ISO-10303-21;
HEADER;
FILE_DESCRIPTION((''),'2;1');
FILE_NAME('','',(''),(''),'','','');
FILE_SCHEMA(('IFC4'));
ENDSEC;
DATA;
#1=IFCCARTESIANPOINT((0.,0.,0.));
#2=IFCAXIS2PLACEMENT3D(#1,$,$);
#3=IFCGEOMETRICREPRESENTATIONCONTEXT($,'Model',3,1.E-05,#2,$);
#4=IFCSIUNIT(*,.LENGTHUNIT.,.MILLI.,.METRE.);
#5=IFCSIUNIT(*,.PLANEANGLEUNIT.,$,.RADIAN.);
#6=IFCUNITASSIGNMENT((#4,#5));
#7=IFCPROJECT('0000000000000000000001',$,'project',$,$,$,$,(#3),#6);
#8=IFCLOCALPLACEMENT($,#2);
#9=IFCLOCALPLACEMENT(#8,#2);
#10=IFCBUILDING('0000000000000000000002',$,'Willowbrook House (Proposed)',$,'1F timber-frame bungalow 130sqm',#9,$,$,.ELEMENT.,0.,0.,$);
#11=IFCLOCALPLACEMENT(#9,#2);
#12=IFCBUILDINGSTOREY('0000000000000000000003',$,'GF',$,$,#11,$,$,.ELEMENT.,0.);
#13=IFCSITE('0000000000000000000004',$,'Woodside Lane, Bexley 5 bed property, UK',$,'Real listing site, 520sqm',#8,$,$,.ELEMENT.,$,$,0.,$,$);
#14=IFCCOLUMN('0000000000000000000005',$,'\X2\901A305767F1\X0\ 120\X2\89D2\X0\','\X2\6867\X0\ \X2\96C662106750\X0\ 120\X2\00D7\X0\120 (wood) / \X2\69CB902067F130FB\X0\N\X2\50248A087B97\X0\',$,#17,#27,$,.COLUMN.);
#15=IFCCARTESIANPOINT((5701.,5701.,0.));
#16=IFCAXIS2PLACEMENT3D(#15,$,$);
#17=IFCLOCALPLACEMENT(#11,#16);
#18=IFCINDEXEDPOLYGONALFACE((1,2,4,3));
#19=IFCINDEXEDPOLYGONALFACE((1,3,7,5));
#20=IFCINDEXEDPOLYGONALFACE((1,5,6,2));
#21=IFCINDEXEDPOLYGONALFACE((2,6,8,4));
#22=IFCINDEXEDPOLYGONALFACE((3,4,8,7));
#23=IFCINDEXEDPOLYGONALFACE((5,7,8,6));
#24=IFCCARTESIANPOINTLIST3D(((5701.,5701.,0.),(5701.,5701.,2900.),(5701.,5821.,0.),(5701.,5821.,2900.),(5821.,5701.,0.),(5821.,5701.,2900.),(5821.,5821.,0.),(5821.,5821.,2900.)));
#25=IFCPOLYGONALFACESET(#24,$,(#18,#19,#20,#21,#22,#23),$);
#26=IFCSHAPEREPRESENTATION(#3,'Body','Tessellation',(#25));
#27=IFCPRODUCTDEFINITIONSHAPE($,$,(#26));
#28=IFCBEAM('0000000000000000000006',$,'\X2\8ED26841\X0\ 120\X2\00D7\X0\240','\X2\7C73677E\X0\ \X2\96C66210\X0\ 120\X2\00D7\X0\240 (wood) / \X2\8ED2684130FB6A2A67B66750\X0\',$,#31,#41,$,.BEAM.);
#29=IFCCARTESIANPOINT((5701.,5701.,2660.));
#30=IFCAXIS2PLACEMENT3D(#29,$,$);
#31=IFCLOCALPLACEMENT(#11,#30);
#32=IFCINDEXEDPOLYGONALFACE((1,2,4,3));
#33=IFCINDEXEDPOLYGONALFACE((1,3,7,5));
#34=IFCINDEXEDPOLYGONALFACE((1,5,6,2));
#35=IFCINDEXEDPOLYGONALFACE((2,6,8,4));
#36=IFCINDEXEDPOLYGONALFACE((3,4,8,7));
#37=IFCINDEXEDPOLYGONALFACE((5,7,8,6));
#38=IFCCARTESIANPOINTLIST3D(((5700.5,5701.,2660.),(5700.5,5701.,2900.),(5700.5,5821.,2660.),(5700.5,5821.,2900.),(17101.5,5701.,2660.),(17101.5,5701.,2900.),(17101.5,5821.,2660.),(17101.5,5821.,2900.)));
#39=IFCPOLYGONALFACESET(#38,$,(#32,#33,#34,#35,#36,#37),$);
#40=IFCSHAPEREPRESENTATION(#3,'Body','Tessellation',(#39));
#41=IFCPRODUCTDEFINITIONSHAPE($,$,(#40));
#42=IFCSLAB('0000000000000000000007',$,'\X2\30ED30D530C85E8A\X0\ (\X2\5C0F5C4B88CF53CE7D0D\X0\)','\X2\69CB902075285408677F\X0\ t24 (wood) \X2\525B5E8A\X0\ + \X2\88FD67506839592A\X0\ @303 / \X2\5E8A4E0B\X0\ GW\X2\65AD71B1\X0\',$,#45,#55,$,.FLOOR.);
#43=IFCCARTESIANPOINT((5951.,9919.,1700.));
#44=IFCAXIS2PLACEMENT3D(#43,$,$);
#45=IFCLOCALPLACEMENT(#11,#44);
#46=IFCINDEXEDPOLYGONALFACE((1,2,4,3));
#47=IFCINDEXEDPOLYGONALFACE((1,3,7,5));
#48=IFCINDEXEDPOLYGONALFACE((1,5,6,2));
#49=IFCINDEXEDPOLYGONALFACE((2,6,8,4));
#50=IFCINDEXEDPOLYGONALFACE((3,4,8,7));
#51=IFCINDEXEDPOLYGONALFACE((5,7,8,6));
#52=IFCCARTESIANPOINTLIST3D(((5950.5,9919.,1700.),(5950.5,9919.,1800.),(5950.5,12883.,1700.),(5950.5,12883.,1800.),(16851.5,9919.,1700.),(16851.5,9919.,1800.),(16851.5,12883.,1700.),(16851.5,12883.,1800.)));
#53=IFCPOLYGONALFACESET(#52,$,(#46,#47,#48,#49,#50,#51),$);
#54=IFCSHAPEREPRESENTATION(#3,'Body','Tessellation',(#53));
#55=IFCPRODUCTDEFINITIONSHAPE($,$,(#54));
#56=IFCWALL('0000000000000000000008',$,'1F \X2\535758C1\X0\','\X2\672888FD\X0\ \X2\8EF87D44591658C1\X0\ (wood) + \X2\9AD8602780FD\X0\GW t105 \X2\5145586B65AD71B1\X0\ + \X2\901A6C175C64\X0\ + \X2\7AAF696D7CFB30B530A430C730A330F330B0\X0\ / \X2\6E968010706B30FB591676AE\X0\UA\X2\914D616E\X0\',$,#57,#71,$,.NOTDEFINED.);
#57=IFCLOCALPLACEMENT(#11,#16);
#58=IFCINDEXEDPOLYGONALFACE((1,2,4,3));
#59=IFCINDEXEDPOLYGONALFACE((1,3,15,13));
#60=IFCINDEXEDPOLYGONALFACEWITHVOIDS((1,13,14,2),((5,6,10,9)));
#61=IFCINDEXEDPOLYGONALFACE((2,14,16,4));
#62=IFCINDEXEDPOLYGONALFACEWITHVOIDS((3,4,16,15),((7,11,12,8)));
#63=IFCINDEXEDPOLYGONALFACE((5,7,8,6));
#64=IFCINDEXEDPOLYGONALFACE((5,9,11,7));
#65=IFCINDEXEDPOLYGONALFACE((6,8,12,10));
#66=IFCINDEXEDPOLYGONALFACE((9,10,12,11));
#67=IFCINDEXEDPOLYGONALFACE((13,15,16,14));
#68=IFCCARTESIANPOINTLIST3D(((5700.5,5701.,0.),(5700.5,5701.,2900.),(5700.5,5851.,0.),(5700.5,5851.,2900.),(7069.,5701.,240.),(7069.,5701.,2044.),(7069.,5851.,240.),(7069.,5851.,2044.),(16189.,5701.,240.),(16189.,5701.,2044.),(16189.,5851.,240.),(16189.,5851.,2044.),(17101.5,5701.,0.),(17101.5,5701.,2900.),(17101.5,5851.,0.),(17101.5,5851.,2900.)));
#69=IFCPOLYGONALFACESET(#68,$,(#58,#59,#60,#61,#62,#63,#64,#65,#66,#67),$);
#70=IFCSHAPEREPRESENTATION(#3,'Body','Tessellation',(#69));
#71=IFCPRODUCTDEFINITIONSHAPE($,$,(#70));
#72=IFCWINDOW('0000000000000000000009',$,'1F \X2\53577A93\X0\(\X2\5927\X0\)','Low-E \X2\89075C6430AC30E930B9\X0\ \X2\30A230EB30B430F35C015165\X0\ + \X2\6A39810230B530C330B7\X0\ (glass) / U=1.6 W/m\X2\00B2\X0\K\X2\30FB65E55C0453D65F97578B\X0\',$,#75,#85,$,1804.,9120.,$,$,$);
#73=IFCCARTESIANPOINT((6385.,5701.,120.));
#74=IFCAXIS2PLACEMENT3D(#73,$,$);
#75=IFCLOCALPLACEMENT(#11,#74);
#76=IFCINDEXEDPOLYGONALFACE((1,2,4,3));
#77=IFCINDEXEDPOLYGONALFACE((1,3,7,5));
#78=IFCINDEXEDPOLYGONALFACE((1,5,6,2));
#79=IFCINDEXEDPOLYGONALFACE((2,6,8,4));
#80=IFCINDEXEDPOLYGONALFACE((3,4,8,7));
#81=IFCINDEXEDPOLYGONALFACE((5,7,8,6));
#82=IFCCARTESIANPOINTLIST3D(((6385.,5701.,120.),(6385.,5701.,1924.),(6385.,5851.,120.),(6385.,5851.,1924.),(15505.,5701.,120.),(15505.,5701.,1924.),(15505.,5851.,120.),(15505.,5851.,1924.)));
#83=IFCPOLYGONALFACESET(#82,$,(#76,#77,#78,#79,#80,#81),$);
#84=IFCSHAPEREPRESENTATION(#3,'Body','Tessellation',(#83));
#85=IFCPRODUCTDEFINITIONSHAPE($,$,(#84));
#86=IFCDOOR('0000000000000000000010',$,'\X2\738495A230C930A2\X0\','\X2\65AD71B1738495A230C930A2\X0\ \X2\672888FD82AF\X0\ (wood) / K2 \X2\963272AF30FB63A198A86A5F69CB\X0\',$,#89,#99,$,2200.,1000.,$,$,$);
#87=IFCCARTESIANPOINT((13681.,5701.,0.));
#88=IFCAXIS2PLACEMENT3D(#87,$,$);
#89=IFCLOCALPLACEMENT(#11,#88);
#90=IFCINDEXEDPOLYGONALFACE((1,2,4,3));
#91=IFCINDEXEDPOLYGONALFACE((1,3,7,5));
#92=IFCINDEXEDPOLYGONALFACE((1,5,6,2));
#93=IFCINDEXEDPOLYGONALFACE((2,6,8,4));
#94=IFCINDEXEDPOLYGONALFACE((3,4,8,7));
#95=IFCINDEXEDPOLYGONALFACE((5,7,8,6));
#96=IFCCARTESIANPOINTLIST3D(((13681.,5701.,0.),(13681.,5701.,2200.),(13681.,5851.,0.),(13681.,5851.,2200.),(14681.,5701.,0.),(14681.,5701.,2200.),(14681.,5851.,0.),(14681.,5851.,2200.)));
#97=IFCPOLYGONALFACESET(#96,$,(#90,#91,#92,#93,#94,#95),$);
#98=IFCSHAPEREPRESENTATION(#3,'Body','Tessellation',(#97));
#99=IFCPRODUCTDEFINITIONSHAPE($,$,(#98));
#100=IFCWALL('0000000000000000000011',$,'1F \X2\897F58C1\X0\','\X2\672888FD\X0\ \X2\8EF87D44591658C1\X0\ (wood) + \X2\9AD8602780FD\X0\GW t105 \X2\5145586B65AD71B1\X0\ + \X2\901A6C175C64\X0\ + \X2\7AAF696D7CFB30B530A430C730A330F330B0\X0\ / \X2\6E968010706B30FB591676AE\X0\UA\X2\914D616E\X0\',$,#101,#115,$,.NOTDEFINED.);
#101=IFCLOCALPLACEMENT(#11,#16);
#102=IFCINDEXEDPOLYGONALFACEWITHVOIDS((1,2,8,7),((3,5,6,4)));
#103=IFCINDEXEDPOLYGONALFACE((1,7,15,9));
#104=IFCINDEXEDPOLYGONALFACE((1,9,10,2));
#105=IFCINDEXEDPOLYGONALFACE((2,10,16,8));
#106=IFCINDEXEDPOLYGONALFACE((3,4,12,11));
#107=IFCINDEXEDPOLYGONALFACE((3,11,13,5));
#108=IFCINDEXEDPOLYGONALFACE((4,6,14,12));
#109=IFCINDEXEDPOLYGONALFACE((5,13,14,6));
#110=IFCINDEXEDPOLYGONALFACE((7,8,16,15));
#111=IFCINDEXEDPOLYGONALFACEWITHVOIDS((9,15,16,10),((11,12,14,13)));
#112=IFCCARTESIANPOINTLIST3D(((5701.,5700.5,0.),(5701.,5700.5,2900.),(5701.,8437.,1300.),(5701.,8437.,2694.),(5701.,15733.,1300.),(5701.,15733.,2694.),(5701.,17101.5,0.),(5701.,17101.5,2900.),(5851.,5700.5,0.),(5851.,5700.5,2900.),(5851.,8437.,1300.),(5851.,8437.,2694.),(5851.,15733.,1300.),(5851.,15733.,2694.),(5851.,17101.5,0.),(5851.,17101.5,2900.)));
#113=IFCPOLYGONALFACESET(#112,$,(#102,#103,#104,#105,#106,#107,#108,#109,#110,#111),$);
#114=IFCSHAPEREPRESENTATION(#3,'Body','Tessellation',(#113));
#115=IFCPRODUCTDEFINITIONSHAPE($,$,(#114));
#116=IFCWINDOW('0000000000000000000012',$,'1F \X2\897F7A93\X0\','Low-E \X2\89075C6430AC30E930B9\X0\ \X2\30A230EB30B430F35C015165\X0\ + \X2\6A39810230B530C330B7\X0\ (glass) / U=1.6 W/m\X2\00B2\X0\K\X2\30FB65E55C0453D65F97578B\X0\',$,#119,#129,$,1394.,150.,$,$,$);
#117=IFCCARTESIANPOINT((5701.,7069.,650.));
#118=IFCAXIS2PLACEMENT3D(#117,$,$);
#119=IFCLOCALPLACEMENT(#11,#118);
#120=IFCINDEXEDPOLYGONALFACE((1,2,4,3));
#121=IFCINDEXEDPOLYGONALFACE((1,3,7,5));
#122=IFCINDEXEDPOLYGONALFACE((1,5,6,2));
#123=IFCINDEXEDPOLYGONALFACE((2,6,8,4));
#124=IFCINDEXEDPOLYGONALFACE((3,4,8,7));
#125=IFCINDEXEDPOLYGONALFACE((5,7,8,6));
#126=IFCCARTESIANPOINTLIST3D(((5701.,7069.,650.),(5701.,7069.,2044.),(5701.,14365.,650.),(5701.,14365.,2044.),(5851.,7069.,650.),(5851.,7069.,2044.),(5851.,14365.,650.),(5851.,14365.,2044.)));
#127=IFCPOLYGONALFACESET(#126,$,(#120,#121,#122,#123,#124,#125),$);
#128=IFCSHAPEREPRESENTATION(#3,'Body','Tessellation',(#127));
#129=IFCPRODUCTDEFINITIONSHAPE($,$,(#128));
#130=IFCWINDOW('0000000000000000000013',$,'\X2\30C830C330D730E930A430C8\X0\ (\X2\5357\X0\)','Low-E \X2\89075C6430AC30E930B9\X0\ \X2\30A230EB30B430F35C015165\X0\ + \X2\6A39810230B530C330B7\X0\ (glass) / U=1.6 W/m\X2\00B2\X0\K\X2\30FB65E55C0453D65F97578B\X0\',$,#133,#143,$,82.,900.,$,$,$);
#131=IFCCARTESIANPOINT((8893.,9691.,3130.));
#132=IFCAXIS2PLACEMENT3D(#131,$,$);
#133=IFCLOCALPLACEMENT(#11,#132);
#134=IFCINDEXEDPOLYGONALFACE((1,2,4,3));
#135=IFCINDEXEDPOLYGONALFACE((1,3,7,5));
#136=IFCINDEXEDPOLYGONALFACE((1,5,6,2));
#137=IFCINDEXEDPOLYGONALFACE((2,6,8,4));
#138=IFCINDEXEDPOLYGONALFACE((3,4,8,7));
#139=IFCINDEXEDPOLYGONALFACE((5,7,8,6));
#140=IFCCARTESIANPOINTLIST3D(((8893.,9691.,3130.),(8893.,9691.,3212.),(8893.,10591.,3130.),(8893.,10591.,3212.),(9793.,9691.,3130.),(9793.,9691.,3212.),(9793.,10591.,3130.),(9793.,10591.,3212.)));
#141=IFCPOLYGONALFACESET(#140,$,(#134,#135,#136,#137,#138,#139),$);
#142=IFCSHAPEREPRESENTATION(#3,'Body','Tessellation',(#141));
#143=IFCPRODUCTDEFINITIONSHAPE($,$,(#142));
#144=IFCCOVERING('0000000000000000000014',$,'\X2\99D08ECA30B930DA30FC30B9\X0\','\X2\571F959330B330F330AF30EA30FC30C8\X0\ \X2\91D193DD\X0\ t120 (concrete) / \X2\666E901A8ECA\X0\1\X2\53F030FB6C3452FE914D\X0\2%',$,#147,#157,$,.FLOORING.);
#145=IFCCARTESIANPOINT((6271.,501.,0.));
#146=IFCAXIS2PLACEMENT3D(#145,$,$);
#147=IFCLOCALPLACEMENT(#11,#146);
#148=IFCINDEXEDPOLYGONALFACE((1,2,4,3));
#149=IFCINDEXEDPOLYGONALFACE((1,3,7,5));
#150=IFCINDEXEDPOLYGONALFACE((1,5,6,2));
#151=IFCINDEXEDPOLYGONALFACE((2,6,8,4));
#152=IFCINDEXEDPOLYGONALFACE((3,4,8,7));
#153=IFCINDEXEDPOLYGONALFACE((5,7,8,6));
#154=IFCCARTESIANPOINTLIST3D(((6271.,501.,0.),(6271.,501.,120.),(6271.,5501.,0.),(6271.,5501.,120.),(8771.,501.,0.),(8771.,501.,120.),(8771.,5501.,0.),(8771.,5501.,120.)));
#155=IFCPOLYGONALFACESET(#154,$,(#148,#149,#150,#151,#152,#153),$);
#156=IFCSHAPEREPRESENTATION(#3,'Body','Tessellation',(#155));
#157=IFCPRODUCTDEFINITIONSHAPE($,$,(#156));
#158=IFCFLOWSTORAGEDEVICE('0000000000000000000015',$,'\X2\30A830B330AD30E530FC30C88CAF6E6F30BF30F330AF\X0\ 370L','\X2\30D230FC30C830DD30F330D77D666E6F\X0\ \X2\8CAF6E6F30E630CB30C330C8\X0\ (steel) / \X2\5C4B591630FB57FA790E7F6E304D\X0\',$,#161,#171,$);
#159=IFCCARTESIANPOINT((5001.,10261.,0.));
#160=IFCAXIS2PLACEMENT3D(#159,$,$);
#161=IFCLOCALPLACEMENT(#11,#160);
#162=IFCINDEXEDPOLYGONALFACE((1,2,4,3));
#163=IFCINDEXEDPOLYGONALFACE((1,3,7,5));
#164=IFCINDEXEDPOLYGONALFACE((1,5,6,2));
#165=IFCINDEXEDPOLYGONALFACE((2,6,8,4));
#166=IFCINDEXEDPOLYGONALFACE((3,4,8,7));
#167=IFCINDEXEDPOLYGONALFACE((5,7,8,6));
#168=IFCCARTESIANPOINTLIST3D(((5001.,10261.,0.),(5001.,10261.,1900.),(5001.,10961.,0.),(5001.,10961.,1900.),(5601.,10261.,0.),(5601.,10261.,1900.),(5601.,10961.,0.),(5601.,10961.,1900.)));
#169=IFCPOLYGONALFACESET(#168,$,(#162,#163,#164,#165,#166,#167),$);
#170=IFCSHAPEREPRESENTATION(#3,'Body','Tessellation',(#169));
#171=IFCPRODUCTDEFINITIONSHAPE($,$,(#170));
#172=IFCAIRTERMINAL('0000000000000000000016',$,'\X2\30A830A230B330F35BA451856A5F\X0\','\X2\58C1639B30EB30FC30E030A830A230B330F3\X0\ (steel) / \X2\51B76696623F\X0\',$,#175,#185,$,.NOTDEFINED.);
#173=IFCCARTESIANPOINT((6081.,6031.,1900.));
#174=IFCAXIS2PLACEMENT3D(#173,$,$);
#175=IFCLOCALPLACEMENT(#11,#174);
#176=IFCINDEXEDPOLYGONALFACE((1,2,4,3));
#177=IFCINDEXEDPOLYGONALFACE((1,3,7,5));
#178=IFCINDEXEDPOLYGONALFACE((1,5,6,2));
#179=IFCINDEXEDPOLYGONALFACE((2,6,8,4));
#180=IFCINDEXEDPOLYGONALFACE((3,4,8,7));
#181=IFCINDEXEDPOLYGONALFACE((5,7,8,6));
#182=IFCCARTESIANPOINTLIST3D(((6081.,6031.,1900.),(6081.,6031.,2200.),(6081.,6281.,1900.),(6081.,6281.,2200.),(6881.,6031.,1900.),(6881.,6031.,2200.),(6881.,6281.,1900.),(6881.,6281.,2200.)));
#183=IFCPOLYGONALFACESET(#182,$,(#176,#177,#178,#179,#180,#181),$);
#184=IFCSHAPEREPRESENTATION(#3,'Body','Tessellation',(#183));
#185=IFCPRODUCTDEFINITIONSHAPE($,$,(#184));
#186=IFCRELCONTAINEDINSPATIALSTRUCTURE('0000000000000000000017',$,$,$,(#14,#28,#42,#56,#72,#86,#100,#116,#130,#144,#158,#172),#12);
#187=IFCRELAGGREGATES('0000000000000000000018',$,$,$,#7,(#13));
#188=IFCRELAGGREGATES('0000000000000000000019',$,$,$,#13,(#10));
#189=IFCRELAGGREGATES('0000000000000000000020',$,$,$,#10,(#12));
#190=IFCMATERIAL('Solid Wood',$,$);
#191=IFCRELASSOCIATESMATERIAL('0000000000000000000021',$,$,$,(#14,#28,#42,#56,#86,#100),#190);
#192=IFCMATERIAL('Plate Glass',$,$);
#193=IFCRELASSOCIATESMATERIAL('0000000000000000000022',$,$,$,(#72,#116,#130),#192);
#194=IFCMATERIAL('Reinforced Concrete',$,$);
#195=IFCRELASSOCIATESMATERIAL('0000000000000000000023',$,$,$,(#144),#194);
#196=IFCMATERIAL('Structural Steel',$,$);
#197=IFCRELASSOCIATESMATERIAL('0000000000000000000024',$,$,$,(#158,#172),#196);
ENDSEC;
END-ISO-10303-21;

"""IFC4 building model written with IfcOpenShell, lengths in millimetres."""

from ifc_helpers import new_model, si_unit, frame, frame_2d, origin, place, context, project, spatial, rectangle, extrude, material, element, fill, save


model = new_model("IFC4")

# Units and contexts
model_context = context("Model", 3, precision=1e-05, world=origin())
ifc_project = project(units=[si_unit("LENGTHUNIT", "METRE", prefix="MILLI"), si_unit("PLANEANGLEUNIT", "RADIAN")], contexts=[model_context])

# Site, building, storey
site_placement = place(None, origin())
site = spatial("IfcSite", under=ifc_project, at=site_placement, Name="Woodside Lane, Bexley 5 bed property, UK", ObjectType="Real listing site, 520sqm", CompositionType="ELEMENT", RefElevation=0.0)
building_placement = place(site_placement, origin())
building = spatial("IfcBuilding", under=site, at=building_placement, Name="Willowbrook House (Proposed)", ObjectType="1F timber-frame bungalow 130sqm", CompositionType="ELEMENT", ElevationOfRefHeight=0.0, ElevationOfTerrain=0.0)
storey_placement = place(building_placement, origin())
storey = spatial("IfcBuildingStorey", under=building, at=storey_placement, Name="GF", CompositionType="ELEMENT", Elevation=0.0)

# Column
ifc_material_1 = material(Name="Solid Wood")
column_1_placement = place(storey_placement, frame((5701.0, 5701.0, 0.0)))
element("IfcColumn", 1, at=column_1_placement, inside=storey, material=ifc_material_1, Name="通し柱 120角", Description="桧 集成材 120×120 (wood) / 構造柱・N値計算", PredefinedType="COLUMN", context=model_context, shape_type="SweptSolid", body=[
    extrude(rectangle(XDim=120.0, YDim=120.0, at=frame_2d((60.0, 60.0))), frame((5701.0, 5701.0, 0.0)), (0.0, 0.0, 1.0), 2900.0),
])

# Beam
beam_1_placement = place(storey_placement, frame((5701.0, 5701.0, 2660.0)))
element("IfcBeam", 2, at=beam_1_placement, inside=storey, material=ifc_material_1, Name="軒桁 120×240", Description="米松 集成 120×240 (wood) / 軒桁・横架材", PredefinedType="BEAM", context=model_context, shape_type="SweptSolid", body=[
    extrude(rectangle(XDim=11401.0, YDim=120.0, at=frame_2d((5700.0, 60.0))), frame((5701.0, 5701.0, 2660.0)), (0.0, 0.0, 1.0), 240.0),
])

# Slab
ifc_material_2 = material(Name="Reinforced Concrete")
slab_1_placement = place(storey_placement, frame((5951.0, 9919.0, 1700.0)))
element("IfcSlab", 3, at=slab_1_placement, inside=storey, material=ifc_material_1, Name="ロフト床 (小屋裏収納)", Description="構造用合板 t24 (wood) 剛床 + 製材根太 @303 / 床下 GW断熱", PredefinedType="FLOOR", context=model_context, shape_type="SweptSolid", body=[
    extrude(rectangle(XDim=10901.0, YDim=2964.0, at=frame_2d((5450.0, 1482.0))), frame((5951.0, 9919.0, 1700.0)), (0.0, 0.0, 1.0), 100.0),
])

# Wall, openings, window, door
wall_1_placement = place(storey_placement, frame((5701.0, 5701.0, 0.0)))
wall_1 = element("IfcWall", 4, at=wall_1_placement, inside=storey, material=ifc_material_1, Name="1F 南壁", Description="木製 軸組外壁 (wood) + 高性能GW t105 充填断熱 + 通気層 + 窯業系サイディング / 準耐火・外皮UA配慮", PredefinedType="NOTDEFINED", context=model_context, shape_type="SweptSolid", body=[
    extrude(rectangle(XDim=11401.0, YDim=150.0, at=frame_2d((5700.0, 75.0))), frame((5701.0, 5701.0, 0.0)), (0.0, 0.0, 1.0), 2900.0),
])
opening_1_placement = place(storey_placement, frame((6385.0, 5701.0, 120.0)))
opening_1 = element("IfcOpeningElement", 5, at=opening_1_placement, cuts=wall_1, PredefinedType="NOTDEFINED", context=model_context, shape_type="SweptSolid", body=[
    extrude(rectangle(XDim=9120.0, YDim=150.0, at=frame_2d((4560.0, 75.0))), frame((6385.0, 5701.0, 120.0)), (0.0, 0.0, 1.0), 1804.0),
])
opening_2_placement = place(storey_placement, frame((13681.0, 5701.0, 0.0)))
opening_2 = element("IfcOpeningElement", 6, at=opening_2_placement, cuts=wall_1, PredefinedType="NOTDEFINED", context=model_context, shape_type="SweptSolid", body=[
    extrude(rectangle(XDim=1000.0, YDim=150.0, at=frame_2d((500.0, 75.0))), frame((13681.0, 5701.0, 0.0)), (0.0, 0.0, 1.0), 2200.0),
])
ifc_material_3 = material(Name="Plate Glass")
window_1_placement = place(storey_placement, frame((6385.0, 5701.0, 120.0)))
window_1 = element("IfcWindow", 7, at=window_1_placement, inside=storey, material=ifc_material_3, Name="1F 南窓(大)", Description="Low-E 複層ガラス アルゴン封入 + 樹脂サッシ (glass) / U=1.6 W/m²K・日射取得型", OverallHeight=1804.0, OverallWidth=9120.0, context=model_context, shape_type="SweptSolid", body=[
    extrude(rectangle(XDim=9120.0, YDim=150.0, at=frame_2d((4560.0, 75.0))), frame((6385.0, 5701.0, 120.0)), (0.0, 0.0, 1.0), 1804.0),
])
fill(opening_1, window_1)
door_placement = place(storey_placement, frame((13681.0, 5701.0, 0.0)))
door = element("IfcDoor", 8, at=door_placement, inside=storey, material=ifc_material_1, Name="玄関ドア", Description="断熱玄関ドア 木製芯 (wood) / K2 防犯・採風機構", OverallHeight=2200.0, OverallWidth=1000.0, context=model_context, shape_type="SweptSolid", body=[
    extrude(rectangle(XDim=1000.0, YDim=150.0, at=frame_2d((500.0, 75.0))), frame((13681.0, 5701.0, 0.0)), (0.0, 0.0, 1.0), 2200.0),
])
fill(opening_2, door)

# Wall, opening, window
wall_2_placement = place(storey_placement, frame((5701.0, 5701.0, 0.0)))
wall_2 = element("IfcWall", 9, at=wall_2_placement, inside=storey, material=ifc_material_1, Name="1F 西壁", Description="木製 軸組外壁 (wood) + 高性能GW t105 充填断熱 + 通気層 + 窯業系サイディング / 準耐火・外皮UA配慮", PredefinedType="NOTDEFINED", context=model_context, shape_type="SweptSolid", body=[
    extrude(rectangle(XDim=150.0, YDim=11401.0, at=frame_2d((75.0, 5700.0))), frame((5701.0, 5701.0, 0.0)), (0.0, 0.0, 1.0), 2900.0),
])
opening_3_placement = place(storey_placement, frame((5701.0, 7069.0, 650.0)))
opening_3 = element("IfcOpeningElement", 10, at=opening_3_placement, cuts=wall_2, PredefinedType="NOTDEFINED", context=model_context, shape_type="SweptSolid", body=[
    extrude(rectangle(XDim=150.0, YDim=7296.0, at=frame_2d((75.0, 3648.0))), frame((5701.0, 7069.0, 650.0)), (0.0, 0.0, 1.0), 1394.0),
])
window_2_placement = place(storey_placement, frame((5701.0, 7069.0, 650.0)))
window_2 = element("IfcWindow", 11, at=window_2_placement, inside=storey, material=ifc_material_3, Name="1F 西窓", Description="Low-E 複層ガラス アルゴン封入 + 樹脂サッシ (glass) / U=1.6 W/m²K・日射取得型", OverallHeight=1394.0, OverallWidth=150.0, context=model_context, shape_type="SweptSolid", body=[
    extrude(rectangle(XDim=150.0, YDim=7296.0, at=frame_2d((75.0, 3648.0))), frame((5701.0, 7069.0, 650.0)), (0.0, 0.0, 1.0), 1394.0),
])
fill(opening_3, window_2)

# Window
window_3_placement = place(storey_placement, frame((8893.0, 9691.0, 3130.0)))
element("IfcWindow", 12, at=window_3_placement, inside=storey, material=ifc_material_3, Name="トップライト (南)", Description="Low-E 複層ガラス アルゴン封入 + 樹脂サッシ (glass) / U=1.6 W/m²K・日射取得型", OverallHeight=82.0, OverallWidth=900.0, context=model_context, shape_type="SweptSolid", body=[
    extrude(rectangle(XDim=900.0, YDim=900.0, at=frame_2d((450.0, 450.0))), frame((8893.0, 9691.0, 3130.0)), (0.0, 0.0, 1.0), 82.0),
])

# Shared definitions
ifc_material_4 = material(Name="Structural Steel")

# Covering
covering_1_placement = place(storey_placement, frame((6271.0, 501.0, 0.0)))
element("IfcCovering", 13, at=covering_1_placement, inside=storey, material=ifc_material_2, Name="駐車スペース", Description="土間コンクリート 金鏝 t120 (concrete) / 普通車1台・水勾配2%", PredefinedType="FLOORING", context=model_context, shape_type="SweptSolid", body=[
    extrude(rectangle(XDim=2500.0, YDim=5000.0, at=frame_2d((1250.0, 2500.0))), frame((6271.0, 501.0, 0.0)), (0.0, 0.0, 1.0), 120.0),
])

# Flow storage device
flow_storage_device_placement = place(storey_placement, frame((5001.0, 10261.0, 0.0)))
element("IfcFlowStorageDevice", 14, at=flow_storage_device_placement, inside=storey, material=ifc_material_4, Name="エコキュート貯湯タンク 370L", Description="ヒートポンプ給湯 貯湯ユニット (steel) / 屋外・基礎置き", context=model_context, shape_type="SweptSolid", body=[
    extrude(rectangle(XDim=600.0, YDim=700.0, at=frame_2d((300.0, 350.0))), frame((5001.0, 10261.0, 0.0)), (0.0, 0.0, 1.0), 1900.0),
])

# Air terminal
air_terminal_placement = place(storey_placement, frame((6081.0, 6031.0, 1900.0)))
element("IfcAirTerminal", 15, at=air_terminal_placement, inside=storey, material=ifc_material_4, Name="エアコン室内機", Description="壁掛ルームエアコン (steel) / 冷暖房", PredefinedType="NOTDEFINED", context=model_context, shape_type="SweptSolid", body=[
    extrude(rectangle(XDim=800.0, YDim=250.0, at=frame_2d((400.0, 125.0))), frame((6081.0, 6031.0, 1900.0)), (0.0, 0.0, 1.0), 300.0),
])

save(model, "model.ifc")
